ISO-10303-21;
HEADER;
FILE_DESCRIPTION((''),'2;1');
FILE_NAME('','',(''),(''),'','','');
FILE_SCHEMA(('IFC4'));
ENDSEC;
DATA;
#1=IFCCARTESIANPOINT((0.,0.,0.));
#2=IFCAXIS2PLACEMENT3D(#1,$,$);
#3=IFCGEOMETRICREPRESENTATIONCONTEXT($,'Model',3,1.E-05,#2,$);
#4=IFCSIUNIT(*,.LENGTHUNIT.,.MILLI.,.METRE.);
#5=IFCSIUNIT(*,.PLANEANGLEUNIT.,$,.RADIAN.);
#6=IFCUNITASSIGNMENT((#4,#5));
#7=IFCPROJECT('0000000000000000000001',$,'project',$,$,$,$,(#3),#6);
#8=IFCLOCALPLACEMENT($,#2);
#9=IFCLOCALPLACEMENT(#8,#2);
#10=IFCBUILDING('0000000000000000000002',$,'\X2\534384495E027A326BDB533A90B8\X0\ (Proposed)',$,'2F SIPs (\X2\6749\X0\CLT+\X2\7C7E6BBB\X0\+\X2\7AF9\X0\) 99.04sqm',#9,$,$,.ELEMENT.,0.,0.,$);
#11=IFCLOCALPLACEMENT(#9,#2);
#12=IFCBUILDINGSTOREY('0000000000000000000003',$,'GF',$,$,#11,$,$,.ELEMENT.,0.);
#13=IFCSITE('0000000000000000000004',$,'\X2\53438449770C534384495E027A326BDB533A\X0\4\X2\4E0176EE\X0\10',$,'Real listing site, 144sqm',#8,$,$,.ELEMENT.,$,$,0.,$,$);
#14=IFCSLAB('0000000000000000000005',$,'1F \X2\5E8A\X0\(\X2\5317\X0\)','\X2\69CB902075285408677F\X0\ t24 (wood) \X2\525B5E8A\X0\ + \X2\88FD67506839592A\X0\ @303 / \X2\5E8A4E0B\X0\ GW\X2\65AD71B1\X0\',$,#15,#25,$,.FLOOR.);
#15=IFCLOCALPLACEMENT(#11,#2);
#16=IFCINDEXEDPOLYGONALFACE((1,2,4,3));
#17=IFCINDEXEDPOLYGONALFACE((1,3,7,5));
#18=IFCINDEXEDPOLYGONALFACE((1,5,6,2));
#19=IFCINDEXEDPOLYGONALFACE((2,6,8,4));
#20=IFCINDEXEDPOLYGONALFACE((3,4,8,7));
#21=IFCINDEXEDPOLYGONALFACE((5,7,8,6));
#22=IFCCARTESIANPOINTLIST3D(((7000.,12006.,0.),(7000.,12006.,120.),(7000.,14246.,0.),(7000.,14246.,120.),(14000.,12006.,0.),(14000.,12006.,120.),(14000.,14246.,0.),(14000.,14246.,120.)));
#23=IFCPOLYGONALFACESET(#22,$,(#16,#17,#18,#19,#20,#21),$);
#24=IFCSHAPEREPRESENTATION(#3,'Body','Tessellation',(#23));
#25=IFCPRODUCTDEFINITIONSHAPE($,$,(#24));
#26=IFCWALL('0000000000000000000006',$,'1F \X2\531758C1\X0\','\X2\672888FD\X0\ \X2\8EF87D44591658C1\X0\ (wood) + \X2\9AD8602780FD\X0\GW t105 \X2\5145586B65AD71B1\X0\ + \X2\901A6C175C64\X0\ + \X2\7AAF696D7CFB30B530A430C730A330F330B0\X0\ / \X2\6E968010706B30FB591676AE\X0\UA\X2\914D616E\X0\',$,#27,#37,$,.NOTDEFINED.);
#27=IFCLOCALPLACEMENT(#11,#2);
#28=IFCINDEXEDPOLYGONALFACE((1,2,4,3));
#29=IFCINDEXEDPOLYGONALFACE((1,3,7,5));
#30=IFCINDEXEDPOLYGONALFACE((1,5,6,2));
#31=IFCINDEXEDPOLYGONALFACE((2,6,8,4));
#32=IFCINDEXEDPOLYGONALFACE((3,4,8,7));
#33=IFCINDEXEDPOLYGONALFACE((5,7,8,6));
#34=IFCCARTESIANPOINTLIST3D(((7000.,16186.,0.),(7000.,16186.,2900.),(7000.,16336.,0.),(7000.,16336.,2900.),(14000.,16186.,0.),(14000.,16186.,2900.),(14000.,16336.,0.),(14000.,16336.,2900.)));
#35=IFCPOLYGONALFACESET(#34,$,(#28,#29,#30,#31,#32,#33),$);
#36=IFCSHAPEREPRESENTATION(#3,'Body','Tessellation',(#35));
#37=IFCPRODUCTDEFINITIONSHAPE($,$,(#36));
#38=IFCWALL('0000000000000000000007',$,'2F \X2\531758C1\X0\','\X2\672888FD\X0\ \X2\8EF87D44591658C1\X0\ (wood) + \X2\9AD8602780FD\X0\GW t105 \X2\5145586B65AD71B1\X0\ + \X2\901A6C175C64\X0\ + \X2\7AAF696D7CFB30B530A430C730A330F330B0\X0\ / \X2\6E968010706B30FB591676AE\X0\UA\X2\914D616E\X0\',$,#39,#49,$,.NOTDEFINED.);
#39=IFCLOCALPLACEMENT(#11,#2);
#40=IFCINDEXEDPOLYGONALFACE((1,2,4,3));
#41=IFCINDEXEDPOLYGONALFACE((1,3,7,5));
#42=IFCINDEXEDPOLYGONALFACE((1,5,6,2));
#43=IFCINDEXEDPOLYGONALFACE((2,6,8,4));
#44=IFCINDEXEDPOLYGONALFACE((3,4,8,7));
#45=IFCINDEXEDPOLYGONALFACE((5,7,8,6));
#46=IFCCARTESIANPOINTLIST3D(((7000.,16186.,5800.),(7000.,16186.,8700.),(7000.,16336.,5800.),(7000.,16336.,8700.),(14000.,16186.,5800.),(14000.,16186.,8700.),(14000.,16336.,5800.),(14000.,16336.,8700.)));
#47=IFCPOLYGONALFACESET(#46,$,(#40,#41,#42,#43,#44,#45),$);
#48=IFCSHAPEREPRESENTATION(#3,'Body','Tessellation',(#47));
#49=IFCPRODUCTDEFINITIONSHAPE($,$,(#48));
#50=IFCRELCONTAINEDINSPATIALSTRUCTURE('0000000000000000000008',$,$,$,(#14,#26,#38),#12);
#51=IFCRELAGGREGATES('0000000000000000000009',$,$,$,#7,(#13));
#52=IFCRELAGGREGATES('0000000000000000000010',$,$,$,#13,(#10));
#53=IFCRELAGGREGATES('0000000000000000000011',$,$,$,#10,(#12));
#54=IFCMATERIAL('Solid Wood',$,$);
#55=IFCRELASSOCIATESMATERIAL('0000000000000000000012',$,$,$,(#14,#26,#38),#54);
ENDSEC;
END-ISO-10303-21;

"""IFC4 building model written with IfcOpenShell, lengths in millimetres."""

from ifc_helpers import new_model, si_unit, frame, frame_2d, origin, place, context, project, spatial, rectangle, extrude, material, element, save


model = new_model("IFC4")

# Units and contexts
model_context = context("Model", 3, precision=1e-05, world=origin())
ifc_project = project(units=[si_unit("LENGTHUNIT", "METRE", prefix="MILLI"), si_unit("PLANEANGLEUNIT", "RADIAN")], contexts=[model_context])

# Site, building, storey
site_placement = place(None, origin())
site = spatial("IfcSite", under=ifc_project, at=site_placement, Name="千葉県千葉市稲毛区4丁目10", ObjectType="Real listing site, 144sqm", CompositionType="ELEMENT", RefElevation=0.0)
building_placement = place(site_placement, origin())
building = spatial("IfcBuilding", under=site, at=building_placement, Name="千葉市稲毛区邸 (Proposed)", ObjectType="2F SIPs (杉CLT+籾殻+竹) 99.04sqm", CompositionType="ELEMENT", ElevationOfRefHeight=0.0, ElevationOfTerrain=0.0)
storey_placement = place(building_placement, origin())
storey = spatial("IfcBuildingStorey", under=building, at=storey_placement, Name="GF", CompositionType="ELEMENT", Elevation=0.0)

# Slab
ifc_material_1 = material(Name="Solid Wood")
slab_1_placement = place(storey_placement, frame((3500.0, 6003.0, 0.0)))
element("IfcSlab", 1, at=slab_1_placement, inside=storey, material=ifc_material_1, Name="1F 床(北)", Description="構造用合板 t24 (wood) 剛床 + 製材根太 @303 / 床下 GW断熱", PredefinedType="FLOOR", context=model_context, shape_type="SweptSolid", body=[
    extrude(rectangle(XDim=7000.0, YDim=2240.0, at=frame_2d((3500.0, 1120.0))), frame((3500.0, 6003.0, 0.0)), (0.0, 0.0, 1.0), 120.0),
])

# Wall
wall_1_placement = place(storey_placement, frame((3500.0, 8093.0, 0.0)))
element("IfcWall", 2, at=wall_1_placement, inside=storey, material=ifc_material_1, Name="1F 北壁", Description="木製 軸組外壁 (wood) + 高性能GW t105 充填断熱 + 通気層 + 窯業系サイディング / 準耐火・外皮UA配慮", PredefinedType="NOTDEFINED", context=model_context, shape_type="SweptSolid", body=[
    extrude(rectangle(XDim=7000.0, YDim=150.0, at=frame_2d((3500.0, 75.0))), frame((3500.0, 8093.0, 0.0)), (0.0, 0.0, 1.0), 2900.0),
])

# Wall
wall_2_placement = place(storey_placement, frame((3500.0, 8093.0, 2900.0)))
element("IfcWall", 3, at=wall_2_placement, inside=storey, material=ifc_material_1, Name="2F 北壁", Description="木製 軸組外壁 (wood) + 高性能GW t105 充填断熱 + 通気層 + 窯業系サイディング / 準耐火・外皮UA配慮", PredefinedType="NOTDEFINED", context=model_context, shape_type="SweptSolid", body=[
    extrude(rectangle(XDim=7000.0, YDim=150.0, at=frame_2d((3500.0, 75.0))), frame((3500.0, 8093.0, 2900.0)), (0.0, 0.0, 1.0), 2900.0),
])

save(model, "model.ifc")
